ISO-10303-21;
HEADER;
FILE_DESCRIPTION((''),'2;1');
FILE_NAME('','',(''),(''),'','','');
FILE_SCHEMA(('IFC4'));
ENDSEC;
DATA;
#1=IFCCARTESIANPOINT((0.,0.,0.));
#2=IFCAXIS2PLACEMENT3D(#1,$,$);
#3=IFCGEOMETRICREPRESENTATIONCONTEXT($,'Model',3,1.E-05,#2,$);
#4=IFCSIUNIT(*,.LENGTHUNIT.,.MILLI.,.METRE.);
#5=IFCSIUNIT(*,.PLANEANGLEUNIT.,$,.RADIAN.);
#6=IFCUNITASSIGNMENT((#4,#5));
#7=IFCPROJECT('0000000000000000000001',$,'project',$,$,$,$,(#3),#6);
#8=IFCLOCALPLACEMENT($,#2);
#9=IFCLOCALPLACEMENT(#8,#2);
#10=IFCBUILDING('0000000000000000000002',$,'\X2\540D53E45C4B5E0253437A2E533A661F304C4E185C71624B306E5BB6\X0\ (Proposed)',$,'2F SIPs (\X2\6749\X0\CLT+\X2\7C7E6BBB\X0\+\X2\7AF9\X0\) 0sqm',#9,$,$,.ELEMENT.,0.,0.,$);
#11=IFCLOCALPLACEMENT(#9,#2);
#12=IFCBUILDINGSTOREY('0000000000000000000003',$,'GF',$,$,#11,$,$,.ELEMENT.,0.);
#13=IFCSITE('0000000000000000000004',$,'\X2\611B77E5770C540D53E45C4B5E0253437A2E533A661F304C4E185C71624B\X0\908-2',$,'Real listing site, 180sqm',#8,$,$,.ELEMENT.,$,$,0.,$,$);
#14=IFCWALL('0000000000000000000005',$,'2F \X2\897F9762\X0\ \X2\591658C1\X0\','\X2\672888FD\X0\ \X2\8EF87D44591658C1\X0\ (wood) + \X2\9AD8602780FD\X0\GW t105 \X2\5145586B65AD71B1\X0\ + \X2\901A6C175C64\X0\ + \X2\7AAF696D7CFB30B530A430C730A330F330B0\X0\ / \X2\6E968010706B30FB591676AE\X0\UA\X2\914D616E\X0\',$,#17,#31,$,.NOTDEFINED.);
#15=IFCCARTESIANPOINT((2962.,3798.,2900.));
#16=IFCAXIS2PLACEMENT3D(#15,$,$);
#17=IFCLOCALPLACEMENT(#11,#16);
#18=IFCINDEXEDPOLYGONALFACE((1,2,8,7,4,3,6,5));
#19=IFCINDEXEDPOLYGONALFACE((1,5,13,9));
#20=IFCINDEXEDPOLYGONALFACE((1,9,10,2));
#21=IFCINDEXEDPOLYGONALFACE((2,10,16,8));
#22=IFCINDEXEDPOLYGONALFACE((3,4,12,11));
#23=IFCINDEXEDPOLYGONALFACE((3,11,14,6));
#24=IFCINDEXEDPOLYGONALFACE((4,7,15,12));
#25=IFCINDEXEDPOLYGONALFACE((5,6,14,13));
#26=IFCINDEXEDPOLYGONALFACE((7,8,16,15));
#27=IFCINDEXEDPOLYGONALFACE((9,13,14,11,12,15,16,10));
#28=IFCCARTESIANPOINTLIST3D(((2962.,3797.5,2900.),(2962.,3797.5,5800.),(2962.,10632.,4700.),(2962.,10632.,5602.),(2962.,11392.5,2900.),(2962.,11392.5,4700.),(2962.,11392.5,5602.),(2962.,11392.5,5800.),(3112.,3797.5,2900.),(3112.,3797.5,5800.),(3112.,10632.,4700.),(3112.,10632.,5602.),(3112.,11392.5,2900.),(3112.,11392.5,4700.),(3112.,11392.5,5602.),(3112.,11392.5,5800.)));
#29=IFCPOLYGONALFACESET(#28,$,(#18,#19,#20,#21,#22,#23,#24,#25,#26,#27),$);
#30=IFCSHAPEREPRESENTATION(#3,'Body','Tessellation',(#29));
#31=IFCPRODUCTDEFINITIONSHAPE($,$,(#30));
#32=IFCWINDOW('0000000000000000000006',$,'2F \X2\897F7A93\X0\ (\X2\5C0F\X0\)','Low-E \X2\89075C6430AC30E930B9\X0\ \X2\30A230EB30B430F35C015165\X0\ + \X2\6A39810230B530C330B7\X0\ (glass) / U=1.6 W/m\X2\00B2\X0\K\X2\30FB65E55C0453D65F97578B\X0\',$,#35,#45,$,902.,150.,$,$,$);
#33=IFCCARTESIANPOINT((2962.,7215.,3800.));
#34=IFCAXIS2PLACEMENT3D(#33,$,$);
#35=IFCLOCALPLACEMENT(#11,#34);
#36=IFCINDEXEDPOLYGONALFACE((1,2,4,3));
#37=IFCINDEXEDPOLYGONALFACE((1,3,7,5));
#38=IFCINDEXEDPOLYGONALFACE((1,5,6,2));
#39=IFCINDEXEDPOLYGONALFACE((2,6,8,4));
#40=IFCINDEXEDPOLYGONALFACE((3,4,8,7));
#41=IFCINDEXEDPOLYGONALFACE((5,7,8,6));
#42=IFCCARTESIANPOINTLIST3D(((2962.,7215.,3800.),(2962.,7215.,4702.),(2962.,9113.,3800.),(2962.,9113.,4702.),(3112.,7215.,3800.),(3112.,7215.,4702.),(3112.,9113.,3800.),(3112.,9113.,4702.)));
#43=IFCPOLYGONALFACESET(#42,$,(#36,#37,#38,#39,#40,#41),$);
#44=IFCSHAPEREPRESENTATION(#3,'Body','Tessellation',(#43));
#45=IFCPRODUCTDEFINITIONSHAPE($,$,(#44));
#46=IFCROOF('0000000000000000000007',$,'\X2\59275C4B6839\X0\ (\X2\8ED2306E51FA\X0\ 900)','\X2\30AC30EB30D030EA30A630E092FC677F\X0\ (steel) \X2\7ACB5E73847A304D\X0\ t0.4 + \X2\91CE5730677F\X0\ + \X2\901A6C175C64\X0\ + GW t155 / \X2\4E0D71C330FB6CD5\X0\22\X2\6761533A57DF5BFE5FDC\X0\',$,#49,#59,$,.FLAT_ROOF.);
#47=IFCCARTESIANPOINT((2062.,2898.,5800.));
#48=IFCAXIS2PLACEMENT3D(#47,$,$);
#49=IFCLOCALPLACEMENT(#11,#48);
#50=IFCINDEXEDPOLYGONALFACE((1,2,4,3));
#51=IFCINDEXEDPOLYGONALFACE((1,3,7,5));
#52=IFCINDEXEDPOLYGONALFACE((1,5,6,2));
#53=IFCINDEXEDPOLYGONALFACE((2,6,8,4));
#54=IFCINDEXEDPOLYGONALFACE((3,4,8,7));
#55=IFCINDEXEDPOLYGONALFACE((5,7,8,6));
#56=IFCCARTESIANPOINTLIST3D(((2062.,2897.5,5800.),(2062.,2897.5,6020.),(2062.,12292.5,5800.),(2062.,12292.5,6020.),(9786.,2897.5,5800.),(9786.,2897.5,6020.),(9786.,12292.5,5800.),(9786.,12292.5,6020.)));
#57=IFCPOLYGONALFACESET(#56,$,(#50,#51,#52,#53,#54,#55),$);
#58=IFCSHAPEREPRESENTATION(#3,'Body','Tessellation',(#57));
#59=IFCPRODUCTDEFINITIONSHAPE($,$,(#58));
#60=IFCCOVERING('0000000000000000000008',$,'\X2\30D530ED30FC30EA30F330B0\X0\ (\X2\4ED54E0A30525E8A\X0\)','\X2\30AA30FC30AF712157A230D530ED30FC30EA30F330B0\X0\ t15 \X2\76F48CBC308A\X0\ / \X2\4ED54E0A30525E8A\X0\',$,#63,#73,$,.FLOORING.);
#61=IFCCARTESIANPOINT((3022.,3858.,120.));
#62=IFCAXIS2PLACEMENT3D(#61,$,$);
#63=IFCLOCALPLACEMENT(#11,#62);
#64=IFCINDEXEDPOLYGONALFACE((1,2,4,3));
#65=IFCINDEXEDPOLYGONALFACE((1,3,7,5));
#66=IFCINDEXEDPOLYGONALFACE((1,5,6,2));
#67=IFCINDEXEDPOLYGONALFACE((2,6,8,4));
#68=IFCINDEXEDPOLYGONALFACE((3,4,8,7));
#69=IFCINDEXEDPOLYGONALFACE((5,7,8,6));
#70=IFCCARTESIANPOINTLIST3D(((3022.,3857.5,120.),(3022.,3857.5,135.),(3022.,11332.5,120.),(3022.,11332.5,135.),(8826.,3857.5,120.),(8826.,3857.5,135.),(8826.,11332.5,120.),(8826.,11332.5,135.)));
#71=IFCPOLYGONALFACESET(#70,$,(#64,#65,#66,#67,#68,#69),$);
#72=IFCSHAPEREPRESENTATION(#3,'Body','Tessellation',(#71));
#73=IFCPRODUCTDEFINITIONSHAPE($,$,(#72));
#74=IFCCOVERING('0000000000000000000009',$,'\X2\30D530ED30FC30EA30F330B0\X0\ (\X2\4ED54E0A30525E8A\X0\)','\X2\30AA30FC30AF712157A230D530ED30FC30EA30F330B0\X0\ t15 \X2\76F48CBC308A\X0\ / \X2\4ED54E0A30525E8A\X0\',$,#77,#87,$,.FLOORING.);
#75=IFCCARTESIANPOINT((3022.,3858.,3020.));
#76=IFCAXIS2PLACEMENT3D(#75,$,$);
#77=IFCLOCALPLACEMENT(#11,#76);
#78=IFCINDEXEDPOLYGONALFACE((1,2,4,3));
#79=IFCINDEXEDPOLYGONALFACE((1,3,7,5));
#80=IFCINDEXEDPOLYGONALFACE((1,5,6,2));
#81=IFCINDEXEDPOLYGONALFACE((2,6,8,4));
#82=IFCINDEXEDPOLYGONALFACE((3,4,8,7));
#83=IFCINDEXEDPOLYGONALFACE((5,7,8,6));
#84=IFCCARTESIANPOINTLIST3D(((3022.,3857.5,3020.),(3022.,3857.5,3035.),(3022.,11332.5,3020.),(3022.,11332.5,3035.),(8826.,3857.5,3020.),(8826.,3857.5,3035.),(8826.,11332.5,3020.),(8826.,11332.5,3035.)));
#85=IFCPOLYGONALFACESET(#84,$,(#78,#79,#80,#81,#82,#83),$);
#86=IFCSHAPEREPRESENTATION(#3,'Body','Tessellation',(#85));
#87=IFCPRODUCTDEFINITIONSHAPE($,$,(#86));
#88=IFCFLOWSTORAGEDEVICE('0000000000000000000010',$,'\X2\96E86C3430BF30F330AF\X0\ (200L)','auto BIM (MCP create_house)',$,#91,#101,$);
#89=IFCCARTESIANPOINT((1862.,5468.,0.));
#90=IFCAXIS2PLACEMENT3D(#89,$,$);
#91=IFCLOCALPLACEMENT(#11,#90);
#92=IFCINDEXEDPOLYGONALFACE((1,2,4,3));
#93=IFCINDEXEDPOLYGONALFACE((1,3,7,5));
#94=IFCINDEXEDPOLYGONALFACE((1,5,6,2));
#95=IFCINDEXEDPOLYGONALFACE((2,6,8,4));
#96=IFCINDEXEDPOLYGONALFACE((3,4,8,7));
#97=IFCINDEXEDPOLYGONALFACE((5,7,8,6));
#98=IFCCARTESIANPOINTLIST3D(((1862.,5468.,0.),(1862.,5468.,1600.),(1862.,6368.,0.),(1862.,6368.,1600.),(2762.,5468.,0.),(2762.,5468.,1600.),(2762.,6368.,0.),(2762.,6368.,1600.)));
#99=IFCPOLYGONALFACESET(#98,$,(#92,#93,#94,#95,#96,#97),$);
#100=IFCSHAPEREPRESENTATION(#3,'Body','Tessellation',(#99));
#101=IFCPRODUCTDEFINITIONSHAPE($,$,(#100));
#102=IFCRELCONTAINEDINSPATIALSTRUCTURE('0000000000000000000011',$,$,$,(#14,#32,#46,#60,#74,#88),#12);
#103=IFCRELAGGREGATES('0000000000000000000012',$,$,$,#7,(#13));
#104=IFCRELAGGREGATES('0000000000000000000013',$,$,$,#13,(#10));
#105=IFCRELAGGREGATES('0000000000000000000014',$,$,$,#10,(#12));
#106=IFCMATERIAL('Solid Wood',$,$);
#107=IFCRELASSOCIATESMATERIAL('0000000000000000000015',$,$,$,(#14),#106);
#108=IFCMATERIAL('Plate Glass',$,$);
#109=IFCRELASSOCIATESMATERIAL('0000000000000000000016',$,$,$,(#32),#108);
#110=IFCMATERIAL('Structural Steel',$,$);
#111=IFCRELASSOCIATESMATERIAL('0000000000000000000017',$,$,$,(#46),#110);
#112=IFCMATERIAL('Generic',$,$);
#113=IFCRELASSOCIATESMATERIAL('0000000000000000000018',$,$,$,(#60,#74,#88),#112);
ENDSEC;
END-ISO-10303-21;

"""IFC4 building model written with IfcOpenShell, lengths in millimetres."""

from ifc_helpers import new_model, si_unit, frame, frame_2d, origin, place, context, project, spatial, rectangle, extrude, material, element, fill, save


model = new_model("IFC4")

# Units and contexts
model_context = context("Model", 3, precision=1e-05, world=origin())
ifc_project = project(units=[si_unit("LENGTHUNIT", "METRE", prefix="MILLI"), si_unit("PLANEANGLEUNIT", "RADIAN")], contexts=[model_context])

# Site, building, storey
site_placement = place(None, origin())
site = spatial("IfcSite", under=ifc_project, at=site_placement, Name="愛知県名古屋市千種区星が丘山手908-2", ObjectType="Real listing site, 180sqm", CompositionType="ELEMENT", RefElevation=0.0)
building_placement = place(site_placement, origin())
building = spatial("IfcBuilding", under=site, at=building_placement, Name="名古屋市千種区星が丘山手の家 (Proposed)", ObjectType="2F SIPs (杉CLT+籾殻+竹) 0sqm", CompositionType="ELEMENT", ElevationOfRefHeight=0.0, ElevationOfTerrain=0.0)
storey_placement = place(building_placement, origin())
storey = spatial("IfcBuildingStorey", under=building, at=storey_placement, Name="GF", CompositionType="ELEMENT", Elevation=0.0)

# Shared definitions
ifc_material_1 = material(Name="Solid Wood")

# Shared definitions
ifc_material_2 = material(Name="Plate Glass")

# Wall, opening, window
wall_1_placement = place(storey_placement, frame((2962.0, 3798.0, 2900.0)))
wall_1 = element("IfcWall", 1, at=wall_1_placement, inside=storey, material=ifc_material_1, Name="2F 西面 外壁", Description="木製 軸組外壁 (wood) + 高性能GW t105 充填断熱 + 通気層 + 窯業系サイディング / 準耐火・外皮UA配慮", PredefinedType="NOTDEFINED", context=model_context, shape_type="SweptSolid", body=[
    extrude(rectangle(XDim=150.0, YDim=7595.0, at=frame_2d((75.0, 3797.0))), frame((2962.0, 3798.0, 2900.0)), (0.0, 0.0, 1.0), 2900.0),
])
opening_1_placement = place(storey_placement, frame((2962.0, 7215.0, 3800.0)))
opening_1 = element("IfcOpeningElement", 2, at=opening_1_placement, cuts=wall_1, PredefinedType="NOTDEFINED", context=model_context, shape_type="SweptSolid", body=[
    extrude(rectangle(XDim=150.0, YDim=1898.0, at=frame_2d((75.0, 949.0))), frame((2962.0, 7215.0, 3800.0)), (0.0, 0.0, 1.0), 902.0),
])
window_1_placement = place(storey_placement, frame((2962.0, 7215.0, 3800.0)))
window_1 = element("IfcWindow", 3, at=window_1_placement, inside=storey, material=ifc_material_2, Name="2F 西窓 (小)", Description="Low-E 複層ガラス アルゴン封入 + 樹脂サッシ (glass) / U=1.6 W/m²K・日射取得型", OverallHeight=902.0, OverallWidth=150.0, context=model_context, shape_type="SweptSolid", body=[
    extrude(rectangle(XDim=150.0, YDim=1898.0, at=frame_2d((75.0, 949.0))), frame((2962.0, 7215.0, 3800.0)), (0.0, 0.0, 1.0), 902.0),
])
fill(opening_1, window_1)

# Roof
ifc_material_3 = material(Name="Structural Steel")
roof_placement = place(storey_placement, frame((2062.0, 2898.0, 5800.0)))
element("IfcRoof", 4, at=roof_placement, inside=storey, material=ifc_material_3, Name="大屋根 (軒の出 900)", Description="ガルバリウム鋼板 (steel) 立平葺き t0.4 + 野地板 + 通気層 + GW t155 / 不燃・法22条区域対応", PredefinedType="FLAT_ROOF", context=model_context, shape_type="SweptSolid", body=[
    extrude(rectangle(XDim=7724.0, YDim=9395.0, at=frame_2d((3862.0, 4697.0))), frame((2062.0, 2898.0, 5800.0)), (0.0, 0.0, 1.0), 220.0),
])

# Coverings
ifc_material_4 = material(Name="Generic")
covering_1_placement = place(storey_placement, frame((3022.0, 3858.0, 120.0)))
element("IfcCovering", 5, at=covering_1_placement, inside=storey, material=ifc_material_4, Name="フローリング (仕上げ床)", Description="オーク無垢フローリング t15 直貼り / 仕上げ床", PredefinedType="FLOORING", context=model_context, shape_type="SweptSolid", body=[
    extrude(rectangle(XDim=5804.0, YDim=7475.0, at=frame_2d((2902.0, 3737.0))), frame((3022.0, 3858.0, 120.0)), (0.0, 0.0, 1.0), 15.0),
])
covering_2_placement = place(storey_placement, frame((3022.0, 3858.0, 3020.0)))
element("IfcCovering", 6, at=covering_2_placement, inside=storey, material=ifc_material_4, Name="フローリング (仕上げ床)", Description="オーク無垢フローリング t15 直貼り / 仕上げ床", PredefinedType="FLOORING", context=model_context, shape_type="SweptSolid", body=[
    extrude(rectangle(XDim=5804.0, YDim=7475.0, at=frame_2d((2902.0, 3737.0))), frame((3022.0, 3858.0, 3020.0)), (0.0, 0.0, 1.0), 15.0),
])

# Flow storage device
flow_storage_device_placement = place(storey_placement, frame((1862.0, 5468.0, 0.0)))
element("IfcFlowStorageDevice", 7, at=flow_storage_device_placement, inside=storey, material=ifc_material_4, Name="雨水タンク (200L)", Description="auto BIM (MCP create_house)", context=model_context, shape_type="SweptSolid", body=[
    extrude(rectangle(XDim=900.0, YDim=900.0, at=frame_2d((450.0, 450.0))), frame((1862.0, 5468.0, 0.0)), (0.0, 0.0, 1.0), 1600.0),
])

save(model, "model.ifc")
